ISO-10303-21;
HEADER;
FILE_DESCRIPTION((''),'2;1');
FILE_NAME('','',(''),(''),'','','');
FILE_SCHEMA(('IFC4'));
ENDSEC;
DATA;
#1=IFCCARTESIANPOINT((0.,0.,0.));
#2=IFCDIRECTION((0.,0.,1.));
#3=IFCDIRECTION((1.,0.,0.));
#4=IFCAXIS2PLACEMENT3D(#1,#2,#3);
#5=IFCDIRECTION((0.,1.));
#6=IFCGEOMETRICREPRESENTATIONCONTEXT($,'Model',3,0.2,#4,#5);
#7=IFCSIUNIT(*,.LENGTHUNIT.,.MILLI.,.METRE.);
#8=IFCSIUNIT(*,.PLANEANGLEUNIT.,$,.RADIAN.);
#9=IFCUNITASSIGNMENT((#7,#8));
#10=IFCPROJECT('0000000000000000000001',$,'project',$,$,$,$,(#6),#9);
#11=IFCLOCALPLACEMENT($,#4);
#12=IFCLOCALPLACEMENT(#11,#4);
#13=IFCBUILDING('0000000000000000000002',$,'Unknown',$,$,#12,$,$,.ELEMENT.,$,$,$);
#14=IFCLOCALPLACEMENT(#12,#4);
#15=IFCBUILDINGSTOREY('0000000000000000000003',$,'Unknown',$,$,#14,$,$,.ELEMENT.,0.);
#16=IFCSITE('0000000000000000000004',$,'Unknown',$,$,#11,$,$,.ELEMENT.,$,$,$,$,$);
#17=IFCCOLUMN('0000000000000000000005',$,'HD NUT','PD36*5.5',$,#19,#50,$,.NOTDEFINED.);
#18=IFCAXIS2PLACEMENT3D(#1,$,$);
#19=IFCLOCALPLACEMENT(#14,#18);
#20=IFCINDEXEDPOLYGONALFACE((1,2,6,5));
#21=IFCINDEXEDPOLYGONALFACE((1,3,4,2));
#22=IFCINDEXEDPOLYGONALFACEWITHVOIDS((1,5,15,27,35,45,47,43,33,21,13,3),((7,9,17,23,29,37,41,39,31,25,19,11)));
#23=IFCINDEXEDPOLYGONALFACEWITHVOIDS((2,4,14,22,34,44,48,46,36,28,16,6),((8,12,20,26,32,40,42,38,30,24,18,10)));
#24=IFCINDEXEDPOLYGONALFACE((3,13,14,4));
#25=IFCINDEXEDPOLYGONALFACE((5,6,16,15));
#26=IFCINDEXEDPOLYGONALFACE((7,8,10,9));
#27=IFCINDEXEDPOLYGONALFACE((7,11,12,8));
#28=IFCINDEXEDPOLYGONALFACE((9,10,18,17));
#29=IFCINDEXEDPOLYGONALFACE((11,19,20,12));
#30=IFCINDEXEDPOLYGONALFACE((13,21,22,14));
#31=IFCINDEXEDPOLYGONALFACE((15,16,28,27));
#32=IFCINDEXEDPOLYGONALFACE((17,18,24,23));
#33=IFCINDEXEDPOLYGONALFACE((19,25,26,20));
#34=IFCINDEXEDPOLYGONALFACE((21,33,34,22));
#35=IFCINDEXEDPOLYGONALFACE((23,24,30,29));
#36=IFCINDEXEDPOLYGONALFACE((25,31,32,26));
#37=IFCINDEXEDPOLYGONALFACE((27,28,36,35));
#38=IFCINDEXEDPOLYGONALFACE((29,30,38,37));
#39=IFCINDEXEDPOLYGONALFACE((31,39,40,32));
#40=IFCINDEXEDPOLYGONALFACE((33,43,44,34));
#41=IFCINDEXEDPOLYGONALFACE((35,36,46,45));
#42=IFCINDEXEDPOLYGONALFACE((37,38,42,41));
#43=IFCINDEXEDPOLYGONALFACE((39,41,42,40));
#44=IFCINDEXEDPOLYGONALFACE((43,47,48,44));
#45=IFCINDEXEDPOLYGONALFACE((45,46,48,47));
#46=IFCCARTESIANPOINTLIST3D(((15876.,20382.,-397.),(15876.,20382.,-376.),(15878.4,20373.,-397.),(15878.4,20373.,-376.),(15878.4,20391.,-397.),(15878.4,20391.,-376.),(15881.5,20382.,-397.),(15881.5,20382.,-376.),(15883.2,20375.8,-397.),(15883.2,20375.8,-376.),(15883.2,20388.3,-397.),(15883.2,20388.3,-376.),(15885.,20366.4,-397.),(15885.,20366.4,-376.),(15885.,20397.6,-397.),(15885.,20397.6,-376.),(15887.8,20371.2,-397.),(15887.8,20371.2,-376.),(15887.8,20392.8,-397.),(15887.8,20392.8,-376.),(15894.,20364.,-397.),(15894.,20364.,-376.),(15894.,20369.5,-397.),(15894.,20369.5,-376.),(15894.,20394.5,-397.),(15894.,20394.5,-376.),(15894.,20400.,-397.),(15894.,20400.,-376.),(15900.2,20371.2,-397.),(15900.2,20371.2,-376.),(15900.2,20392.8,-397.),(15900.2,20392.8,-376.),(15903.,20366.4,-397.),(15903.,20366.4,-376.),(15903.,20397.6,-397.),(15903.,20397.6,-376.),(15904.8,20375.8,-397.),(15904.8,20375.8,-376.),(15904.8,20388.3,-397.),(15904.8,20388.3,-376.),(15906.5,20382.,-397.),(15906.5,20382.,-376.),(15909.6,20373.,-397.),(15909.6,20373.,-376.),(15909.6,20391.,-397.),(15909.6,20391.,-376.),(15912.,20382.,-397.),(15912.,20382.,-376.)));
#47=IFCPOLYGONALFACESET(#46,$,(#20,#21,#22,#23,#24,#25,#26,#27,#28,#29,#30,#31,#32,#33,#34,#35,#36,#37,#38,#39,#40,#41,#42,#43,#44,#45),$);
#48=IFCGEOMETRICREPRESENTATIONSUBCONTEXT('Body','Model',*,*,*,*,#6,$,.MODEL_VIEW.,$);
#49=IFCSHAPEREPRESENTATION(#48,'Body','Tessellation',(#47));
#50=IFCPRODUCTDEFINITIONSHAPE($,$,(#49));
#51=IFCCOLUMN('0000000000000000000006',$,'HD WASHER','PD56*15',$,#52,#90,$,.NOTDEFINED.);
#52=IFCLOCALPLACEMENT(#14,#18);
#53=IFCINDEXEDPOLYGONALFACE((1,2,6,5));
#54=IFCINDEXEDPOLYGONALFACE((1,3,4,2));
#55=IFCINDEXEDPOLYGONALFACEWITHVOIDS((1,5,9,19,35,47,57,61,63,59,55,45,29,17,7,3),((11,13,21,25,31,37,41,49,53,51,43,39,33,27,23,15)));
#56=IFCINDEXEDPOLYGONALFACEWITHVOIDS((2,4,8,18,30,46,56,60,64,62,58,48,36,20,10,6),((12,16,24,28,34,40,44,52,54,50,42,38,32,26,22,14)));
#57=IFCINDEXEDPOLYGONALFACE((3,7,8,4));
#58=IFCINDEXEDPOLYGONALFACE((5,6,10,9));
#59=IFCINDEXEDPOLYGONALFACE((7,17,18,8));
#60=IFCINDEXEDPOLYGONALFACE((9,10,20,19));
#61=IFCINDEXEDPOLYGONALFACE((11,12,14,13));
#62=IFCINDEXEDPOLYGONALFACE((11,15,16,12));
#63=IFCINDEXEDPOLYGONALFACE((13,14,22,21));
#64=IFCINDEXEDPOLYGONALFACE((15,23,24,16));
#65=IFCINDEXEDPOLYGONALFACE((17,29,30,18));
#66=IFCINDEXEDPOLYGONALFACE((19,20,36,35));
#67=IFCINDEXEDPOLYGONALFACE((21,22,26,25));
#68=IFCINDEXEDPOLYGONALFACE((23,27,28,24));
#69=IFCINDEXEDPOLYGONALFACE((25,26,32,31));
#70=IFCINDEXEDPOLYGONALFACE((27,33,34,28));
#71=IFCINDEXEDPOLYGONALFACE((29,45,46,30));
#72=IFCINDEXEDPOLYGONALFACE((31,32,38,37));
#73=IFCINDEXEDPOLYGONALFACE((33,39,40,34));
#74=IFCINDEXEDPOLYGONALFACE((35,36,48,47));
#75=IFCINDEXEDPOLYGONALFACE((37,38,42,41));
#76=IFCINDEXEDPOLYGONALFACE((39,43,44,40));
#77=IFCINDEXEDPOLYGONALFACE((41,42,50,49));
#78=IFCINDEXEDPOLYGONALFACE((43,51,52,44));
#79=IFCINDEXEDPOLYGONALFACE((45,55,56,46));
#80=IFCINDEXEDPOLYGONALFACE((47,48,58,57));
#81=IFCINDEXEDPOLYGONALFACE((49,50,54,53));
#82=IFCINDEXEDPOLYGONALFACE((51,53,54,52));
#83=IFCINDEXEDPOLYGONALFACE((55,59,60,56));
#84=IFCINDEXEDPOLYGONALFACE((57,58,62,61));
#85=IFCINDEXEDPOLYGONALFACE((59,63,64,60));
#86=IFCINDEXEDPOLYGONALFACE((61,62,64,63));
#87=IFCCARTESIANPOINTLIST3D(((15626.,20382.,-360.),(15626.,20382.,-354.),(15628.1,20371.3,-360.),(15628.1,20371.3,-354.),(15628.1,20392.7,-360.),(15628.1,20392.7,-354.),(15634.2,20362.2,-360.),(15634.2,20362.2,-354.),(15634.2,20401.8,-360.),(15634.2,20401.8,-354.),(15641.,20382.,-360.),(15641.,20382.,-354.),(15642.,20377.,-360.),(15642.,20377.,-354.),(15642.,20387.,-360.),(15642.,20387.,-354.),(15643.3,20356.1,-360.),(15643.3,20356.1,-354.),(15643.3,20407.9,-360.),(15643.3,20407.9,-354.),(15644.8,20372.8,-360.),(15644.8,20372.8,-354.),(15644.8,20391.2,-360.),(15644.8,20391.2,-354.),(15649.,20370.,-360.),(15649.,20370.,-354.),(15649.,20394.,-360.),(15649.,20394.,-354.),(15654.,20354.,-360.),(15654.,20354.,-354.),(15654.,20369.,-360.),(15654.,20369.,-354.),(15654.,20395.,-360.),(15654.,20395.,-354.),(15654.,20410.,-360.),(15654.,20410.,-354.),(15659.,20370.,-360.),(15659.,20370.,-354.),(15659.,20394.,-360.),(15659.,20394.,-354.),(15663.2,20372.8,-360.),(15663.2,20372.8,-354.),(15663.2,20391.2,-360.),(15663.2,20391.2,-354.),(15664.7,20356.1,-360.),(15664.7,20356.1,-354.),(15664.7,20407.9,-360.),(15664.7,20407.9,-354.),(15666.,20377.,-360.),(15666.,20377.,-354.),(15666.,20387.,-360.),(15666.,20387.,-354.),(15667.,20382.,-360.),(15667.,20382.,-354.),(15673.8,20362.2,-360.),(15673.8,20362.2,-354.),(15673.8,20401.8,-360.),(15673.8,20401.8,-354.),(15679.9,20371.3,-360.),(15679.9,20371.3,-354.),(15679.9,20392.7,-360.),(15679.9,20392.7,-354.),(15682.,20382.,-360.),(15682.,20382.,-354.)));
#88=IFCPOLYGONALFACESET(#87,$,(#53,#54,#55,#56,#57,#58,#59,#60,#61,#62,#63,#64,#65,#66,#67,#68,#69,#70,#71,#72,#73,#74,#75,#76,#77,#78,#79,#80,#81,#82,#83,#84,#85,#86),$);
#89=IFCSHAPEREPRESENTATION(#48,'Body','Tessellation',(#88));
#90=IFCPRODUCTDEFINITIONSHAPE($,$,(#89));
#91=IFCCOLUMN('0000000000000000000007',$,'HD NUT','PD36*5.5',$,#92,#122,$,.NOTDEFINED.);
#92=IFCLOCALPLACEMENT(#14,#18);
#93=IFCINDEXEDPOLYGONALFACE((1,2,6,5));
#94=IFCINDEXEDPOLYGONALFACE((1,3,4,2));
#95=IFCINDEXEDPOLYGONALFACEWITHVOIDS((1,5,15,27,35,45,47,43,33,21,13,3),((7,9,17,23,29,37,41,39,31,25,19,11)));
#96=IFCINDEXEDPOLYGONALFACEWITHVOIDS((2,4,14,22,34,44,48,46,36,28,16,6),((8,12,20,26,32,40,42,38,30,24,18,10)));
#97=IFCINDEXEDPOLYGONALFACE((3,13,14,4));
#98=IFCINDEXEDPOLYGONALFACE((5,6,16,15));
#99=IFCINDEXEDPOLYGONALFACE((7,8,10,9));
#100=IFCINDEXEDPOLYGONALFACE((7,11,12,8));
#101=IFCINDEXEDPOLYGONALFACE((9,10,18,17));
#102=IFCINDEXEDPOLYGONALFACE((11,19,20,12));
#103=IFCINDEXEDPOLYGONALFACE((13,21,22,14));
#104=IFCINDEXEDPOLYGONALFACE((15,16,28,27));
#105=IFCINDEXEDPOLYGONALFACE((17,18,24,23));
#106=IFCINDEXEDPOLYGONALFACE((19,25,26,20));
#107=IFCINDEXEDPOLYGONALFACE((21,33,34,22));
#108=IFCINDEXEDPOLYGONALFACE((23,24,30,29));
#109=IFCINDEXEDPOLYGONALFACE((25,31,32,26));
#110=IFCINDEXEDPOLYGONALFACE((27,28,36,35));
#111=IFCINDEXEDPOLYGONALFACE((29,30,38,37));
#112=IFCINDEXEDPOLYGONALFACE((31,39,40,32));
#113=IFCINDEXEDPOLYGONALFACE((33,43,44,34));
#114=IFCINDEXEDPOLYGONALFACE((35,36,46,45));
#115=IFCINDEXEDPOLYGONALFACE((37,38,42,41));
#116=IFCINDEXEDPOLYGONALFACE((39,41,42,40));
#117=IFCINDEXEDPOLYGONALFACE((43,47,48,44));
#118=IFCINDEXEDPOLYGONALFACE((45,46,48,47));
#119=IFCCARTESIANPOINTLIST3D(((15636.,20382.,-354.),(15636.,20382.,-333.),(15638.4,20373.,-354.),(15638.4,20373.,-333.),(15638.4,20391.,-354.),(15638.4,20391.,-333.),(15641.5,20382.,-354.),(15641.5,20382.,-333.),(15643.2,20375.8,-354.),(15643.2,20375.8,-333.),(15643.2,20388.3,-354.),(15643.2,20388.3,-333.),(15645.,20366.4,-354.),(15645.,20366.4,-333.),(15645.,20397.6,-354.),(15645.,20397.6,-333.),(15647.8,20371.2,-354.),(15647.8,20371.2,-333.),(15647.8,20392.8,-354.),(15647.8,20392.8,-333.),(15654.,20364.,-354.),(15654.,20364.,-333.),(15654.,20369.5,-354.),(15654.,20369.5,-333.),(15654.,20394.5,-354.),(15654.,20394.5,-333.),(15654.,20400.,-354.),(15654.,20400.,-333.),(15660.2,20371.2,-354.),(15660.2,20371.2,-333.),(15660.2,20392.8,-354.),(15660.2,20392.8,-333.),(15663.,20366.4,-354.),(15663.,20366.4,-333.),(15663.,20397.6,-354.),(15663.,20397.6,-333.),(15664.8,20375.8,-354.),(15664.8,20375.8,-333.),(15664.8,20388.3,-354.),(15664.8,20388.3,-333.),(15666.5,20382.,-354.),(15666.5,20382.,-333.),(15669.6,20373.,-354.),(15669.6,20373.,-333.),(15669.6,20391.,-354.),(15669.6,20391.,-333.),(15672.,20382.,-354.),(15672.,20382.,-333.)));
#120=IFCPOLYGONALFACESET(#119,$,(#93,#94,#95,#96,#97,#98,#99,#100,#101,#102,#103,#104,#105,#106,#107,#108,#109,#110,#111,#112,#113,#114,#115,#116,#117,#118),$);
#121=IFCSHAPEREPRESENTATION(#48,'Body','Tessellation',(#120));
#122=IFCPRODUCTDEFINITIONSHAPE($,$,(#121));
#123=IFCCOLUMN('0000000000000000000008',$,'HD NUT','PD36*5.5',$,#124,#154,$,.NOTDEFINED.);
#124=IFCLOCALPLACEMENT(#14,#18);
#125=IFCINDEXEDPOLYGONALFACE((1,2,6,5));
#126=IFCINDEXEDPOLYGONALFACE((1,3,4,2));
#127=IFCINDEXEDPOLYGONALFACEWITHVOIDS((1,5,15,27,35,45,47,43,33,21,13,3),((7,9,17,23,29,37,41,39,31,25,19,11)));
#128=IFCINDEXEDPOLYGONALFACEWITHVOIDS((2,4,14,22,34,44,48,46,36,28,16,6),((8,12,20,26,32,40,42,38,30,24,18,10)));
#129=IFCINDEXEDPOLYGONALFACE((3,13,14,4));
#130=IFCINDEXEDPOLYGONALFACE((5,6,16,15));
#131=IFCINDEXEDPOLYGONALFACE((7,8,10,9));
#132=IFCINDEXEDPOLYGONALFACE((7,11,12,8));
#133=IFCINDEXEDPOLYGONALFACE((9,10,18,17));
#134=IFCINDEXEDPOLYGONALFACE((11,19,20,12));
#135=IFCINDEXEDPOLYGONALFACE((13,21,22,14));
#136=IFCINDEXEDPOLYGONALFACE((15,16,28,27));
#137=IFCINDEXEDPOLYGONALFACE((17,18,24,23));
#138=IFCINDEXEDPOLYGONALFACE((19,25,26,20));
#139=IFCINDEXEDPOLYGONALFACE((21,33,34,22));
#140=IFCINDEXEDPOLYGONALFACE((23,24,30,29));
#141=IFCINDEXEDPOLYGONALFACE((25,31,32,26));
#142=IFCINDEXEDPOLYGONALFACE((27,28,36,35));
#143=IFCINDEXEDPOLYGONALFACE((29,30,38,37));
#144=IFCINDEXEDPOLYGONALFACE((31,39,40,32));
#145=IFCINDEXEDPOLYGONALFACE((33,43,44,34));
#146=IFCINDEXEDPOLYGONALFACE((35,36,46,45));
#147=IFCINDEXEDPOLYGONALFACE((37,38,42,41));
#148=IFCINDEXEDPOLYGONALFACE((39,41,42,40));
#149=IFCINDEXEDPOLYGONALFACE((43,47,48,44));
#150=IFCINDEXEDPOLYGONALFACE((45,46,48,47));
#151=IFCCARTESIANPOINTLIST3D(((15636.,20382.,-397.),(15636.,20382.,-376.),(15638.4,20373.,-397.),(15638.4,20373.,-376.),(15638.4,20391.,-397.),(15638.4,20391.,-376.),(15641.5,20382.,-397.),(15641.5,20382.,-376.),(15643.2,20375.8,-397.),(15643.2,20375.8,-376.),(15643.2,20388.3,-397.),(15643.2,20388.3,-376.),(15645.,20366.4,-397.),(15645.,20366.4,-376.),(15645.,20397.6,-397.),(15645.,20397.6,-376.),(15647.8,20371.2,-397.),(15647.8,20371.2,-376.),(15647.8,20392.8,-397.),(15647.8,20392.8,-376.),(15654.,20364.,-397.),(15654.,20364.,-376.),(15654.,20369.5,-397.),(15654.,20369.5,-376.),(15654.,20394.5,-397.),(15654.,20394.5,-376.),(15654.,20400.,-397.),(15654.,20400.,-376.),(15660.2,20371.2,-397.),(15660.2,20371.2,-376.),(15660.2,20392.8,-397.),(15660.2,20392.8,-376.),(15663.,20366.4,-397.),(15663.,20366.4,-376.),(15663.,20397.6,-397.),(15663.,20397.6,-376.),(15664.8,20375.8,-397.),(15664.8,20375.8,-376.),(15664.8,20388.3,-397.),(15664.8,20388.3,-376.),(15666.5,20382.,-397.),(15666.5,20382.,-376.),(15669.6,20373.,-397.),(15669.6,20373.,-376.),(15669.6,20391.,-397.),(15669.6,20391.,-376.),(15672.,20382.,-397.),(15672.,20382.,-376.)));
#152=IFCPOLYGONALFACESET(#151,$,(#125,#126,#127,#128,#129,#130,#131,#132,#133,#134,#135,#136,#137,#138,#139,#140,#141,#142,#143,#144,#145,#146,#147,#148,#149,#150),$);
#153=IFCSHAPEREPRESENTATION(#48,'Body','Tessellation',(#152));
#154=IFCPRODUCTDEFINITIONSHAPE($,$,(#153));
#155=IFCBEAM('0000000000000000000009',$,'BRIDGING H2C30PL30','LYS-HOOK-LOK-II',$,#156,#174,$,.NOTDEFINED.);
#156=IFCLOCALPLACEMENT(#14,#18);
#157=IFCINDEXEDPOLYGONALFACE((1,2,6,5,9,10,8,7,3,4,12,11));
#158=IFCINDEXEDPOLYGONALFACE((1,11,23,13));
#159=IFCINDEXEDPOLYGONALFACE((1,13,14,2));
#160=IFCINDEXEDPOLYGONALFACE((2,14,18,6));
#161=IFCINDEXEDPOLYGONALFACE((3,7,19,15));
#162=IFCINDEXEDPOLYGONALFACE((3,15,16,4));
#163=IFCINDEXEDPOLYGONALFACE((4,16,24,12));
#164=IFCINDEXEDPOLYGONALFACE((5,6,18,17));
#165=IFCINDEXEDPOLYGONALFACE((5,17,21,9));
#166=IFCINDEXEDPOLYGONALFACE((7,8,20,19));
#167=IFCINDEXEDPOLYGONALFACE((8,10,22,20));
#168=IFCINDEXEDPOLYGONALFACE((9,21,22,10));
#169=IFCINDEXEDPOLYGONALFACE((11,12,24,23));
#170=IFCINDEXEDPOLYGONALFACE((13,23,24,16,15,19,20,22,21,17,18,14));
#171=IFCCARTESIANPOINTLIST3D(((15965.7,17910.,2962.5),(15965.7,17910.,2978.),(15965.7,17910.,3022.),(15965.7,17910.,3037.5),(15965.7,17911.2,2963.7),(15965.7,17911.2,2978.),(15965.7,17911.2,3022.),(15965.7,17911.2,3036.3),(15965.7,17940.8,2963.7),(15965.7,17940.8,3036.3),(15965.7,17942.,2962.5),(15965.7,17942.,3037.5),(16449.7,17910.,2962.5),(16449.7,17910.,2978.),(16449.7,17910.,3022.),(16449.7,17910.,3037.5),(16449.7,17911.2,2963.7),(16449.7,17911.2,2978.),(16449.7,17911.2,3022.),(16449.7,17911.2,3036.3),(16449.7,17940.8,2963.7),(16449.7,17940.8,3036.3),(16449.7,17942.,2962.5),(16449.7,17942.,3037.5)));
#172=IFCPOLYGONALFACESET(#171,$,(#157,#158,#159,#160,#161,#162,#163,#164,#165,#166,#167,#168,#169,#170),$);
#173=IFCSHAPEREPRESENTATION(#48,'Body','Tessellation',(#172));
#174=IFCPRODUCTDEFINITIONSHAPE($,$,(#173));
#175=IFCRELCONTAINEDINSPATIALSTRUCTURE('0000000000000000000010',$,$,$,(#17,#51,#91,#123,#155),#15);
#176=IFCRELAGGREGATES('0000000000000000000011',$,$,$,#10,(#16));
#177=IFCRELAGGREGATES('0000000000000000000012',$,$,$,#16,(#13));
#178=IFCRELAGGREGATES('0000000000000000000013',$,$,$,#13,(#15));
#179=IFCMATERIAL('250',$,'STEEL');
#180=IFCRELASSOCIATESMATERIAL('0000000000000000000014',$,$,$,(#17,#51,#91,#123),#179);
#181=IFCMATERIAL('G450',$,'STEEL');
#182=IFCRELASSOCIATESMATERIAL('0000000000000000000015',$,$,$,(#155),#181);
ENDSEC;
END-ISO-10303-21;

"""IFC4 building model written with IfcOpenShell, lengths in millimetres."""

from ifc_helpers import new_model, si_unit, direction, frame, origin_with_axes, place, context, subcontext, project, spatial, line, indexed_curve, outline, extrude, material, element, save


model = new_model("IFC4")

# Units and contexts
model_context = context("Model", 3, precision=0.2, world=origin_with_axes(), true_north=direction((0.0, 1.0)))
body_context = subcontext(model_context, "Body", "Model", "MODEL_VIEW")
ifc_project = project(units=[si_unit("LENGTHUNIT", "METRE", prefix="MILLI"), si_unit("PLANEANGLEUNIT", "RADIAN")], contexts=[model_context])

# Site, building, storey
site_placement = place(None, origin_with_axes())
site = spatial("IfcSite", under=ifc_project, at=site_placement, Name="Unknown", CompositionType="ELEMENT")
building_placement = place(site_placement, origin_with_axes())
building = spatial("IfcBuilding", under=site, at=building_placement, Name="Unknown", CompositionType="ELEMENT")
storey_placement = place(building_placement, origin_with_axes())
storey = spatial("IfcBuildingStorey", under=building, at=storey_placement, Name="Unknown", CompositionType="ELEMENT", Elevation=0.0)

# Columns
ifc_material_1 = material(Name="250", Category="STEEL")
column_1_placement = place(storey_placement, frame((15894.0, 20382.0, -397.0), z_axis=(-1.0, 0.0, 0.0), x_axis=(0.0, 0.0, 1.0)))
element("IfcColumn", 1, at=column_1_placement, inside=storey, material=ifc_material_1, Name="HD NUT", Description="PD36*5.5", PredefinedType="NOTDEFINED", context=body_context, shape_type="SolidModel", body=[
    extrude(outline(indexed_curve([(18.0, 0.0), (15.6, 9.0), (9.0, 15.6), (0.0, 18.0), (-9.0, 15.6), (-15.6, 9.0), (-18.0, 0.0), (-15.6, -9.0), (-9.0, -15.6), (0.0, -18.0), (9.0, -15.6), (15.6, -9.0)], segments=[line(1, 2, 3, 4, 5, 6, 7, 8, 9, 10, 11, 12, 1)]), holes=[indexed_curve([(12.5, 0.0), (10.8, -6.2), (6.2, -10.8), (0.0, -12.5), (-6.2, -10.8), (-10.8, -6.2), (-12.5, 0.0), (-10.8, 6.2), (-6.2, 10.8), (0.0, 12.5), (6.2, 10.8), (10.8, 6.2)], segments=[line(1, 2, 3, 4, 5, 6, 7, 8, 9, 10, 11, 12, 1)])]), frame((0.0, 0.0, 0.0), z_axis=(-1.0, 0.0, 0.0), x_axis=(0.0, 0.0, 1.0)), (0.0, 0.0, -1.0), 21.0),
])
column_2_placement = place(storey_placement, frame((15654.0, 20382.0, -360.0), z_axis=(-1.0, 0.0, 0.0), x_axis=(0.0, 0.0, 1.0)))
element("IfcColumn", 2, at=column_2_placement, inside=storey, material=ifc_material_1, Name="HD WASHER", Description="PD56*15", PredefinedType="NOTDEFINED", context=body_context, shape_type="SolidModel", body=[
    extrude(outline(indexed_curve([(28.0, 0.0), (25.9, 10.7), (19.8, 19.8), (10.7, 25.9), (0.0, 28.0), (-10.7, 25.9), (-19.8, 19.8), (-25.9, 10.7), (-28.0, 0.0), (-25.9, -10.7), (-19.8, -19.8), (-10.7, -25.9), (0.0, -28.0), (10.7, -25.9), (19.8, -19.8), (25.9, -10.7)], segments=[line(1, 2, 3, 4, 5, 6, 7, 8, 9, 10, 11, 12, 13, 14, 15, 16, 1)]), holes=[indexed_curve([(13.0, 0.0), (12.0, -5.0), (9.2, -9.2), (5.0, -12.0), (0.0, -13.0), (-5.0, -12.0), (-9.2, -9.2), (-12.0, -5.0), (-13.0, 0.0), (-12.0, 5.0), (-9.2, 9.2), (-5.0, 12.0), (0.0, 13.0), (5.0, 12.0), (9.2, 9.2), (12.0, 5.0)], segments=[line(1, 2, 3, 4, 5, 6, 7, 8, 9, 10, 11, 12, 13, 14, 15, 16, 1)])]), frame((0.0, 0.0, 0.0), z_axis=(-1.0, 0.0, 0.0), x_axis=(0.0, 0.0, 1.0)), (0.0, 0.0, -1.0), 6.0),
])
for number, where, z_axis, x_axis, name in (
    (3, (15654.0, 20382.0, -354.0), (-1.0, 0.0, 0.0), (0.0, 0.0, 1.0), "HD NUT"),
    (4, (15654.0, 20382.0, -397.0), (-1.0, 0.0, 0.0), (0.0, 0.0, 1.0), "HD NUT"),
):
    element("IfcColumn", number, at=place(storey_placement, frame(where, z_axis=z_axis, x_axis=x_axis)), inside=storey, material=ifc_material_1, Name=name, Description="PD36*5.5", PredefinedType="NOTDEFINED", context=body_context, shape_type="SolidModel", body=[
        extrude(outline(indexed_curve([(18.0, 0.0), (15.6, 9.0), (9.0, 15.6), (0.0, 18.0), (-9.0, 15.6), (-15.6, 9.0), (-18.0, 0.0), (-15.6, -9.0), (-9.0, -15.6), (0.0, -18.0), (9.0, -15.6), (15.6, -9.0)], segments=[line(1, 2, 3, 4, 5, 6, 7, 8, 9, 10, 11, 12, 1)]), holes=[indexed_curve([(12.5, 0.0), (10.8, -6.2), (6.2, -10.8), (0.0, -12.5), (-6.2, -10.8), (-10.8, -6.2), (-12.5, 0.0), (-10.8, 6.2), (-6.2, 10.8), (0.0, 12.5), (6.2, 10.8), (10.8, 6.2)], segments=[line(1, 2, 3, 4, 5, 6, 7, 8, 9, 10, 11, 12, 1)])]), frame((0.0, 0.0, 0.0), z_axis=(-1.0, 0.0, 0.0), x_axis=(0.0, 0.0, 1.0)), (0.0, 0.0, -1.0), 21.0),
    ])

# Beam
ifc_material_2 = material(Name="G450", Category="STEEL")
beam_1_placement = place(storey_placement, frame((15965.7, 17926.0, 3000.0), z_axis=(0.0, -1.0, 0.0), x_axis=(1.0, 0.0, 0.0)))
element("IfcBeam", 5, at=beam_1_placement, inside=storey, material=ifc_material_2, Name="BRIDGING H2C30PL30", Description="LYS-HOOK-LOK-II", PredefinedType="NOTDEFINED", context=body_context, shape_type="SolidModel", body=[
    extrude(outline(indexed_curve([(16.0, -37.5), (16.0, -22.0), (14.8, -22.0), (14.8, -36.3), (-14.8, -36.3), (-14.8, 36.3), (14.8, 36.3), (14.8, 22.0), (16.0, 22.0), (16.0, 37.5), (-16.0, 37.5), (-16.0, -37.5)], segments=[line(1, 2, 3, 4, 5, 6, 7, 8, 9, 10, 11, 12, 1)])), frame((0.0, 0.0, 0.0), z_axis=(-1.0, 0.0, 0.0), x_axis=(0.0, 0.0, 1.0)), (0.0, 0.0, -1.0), 484.0),
])

save(model, "model.ifc")
